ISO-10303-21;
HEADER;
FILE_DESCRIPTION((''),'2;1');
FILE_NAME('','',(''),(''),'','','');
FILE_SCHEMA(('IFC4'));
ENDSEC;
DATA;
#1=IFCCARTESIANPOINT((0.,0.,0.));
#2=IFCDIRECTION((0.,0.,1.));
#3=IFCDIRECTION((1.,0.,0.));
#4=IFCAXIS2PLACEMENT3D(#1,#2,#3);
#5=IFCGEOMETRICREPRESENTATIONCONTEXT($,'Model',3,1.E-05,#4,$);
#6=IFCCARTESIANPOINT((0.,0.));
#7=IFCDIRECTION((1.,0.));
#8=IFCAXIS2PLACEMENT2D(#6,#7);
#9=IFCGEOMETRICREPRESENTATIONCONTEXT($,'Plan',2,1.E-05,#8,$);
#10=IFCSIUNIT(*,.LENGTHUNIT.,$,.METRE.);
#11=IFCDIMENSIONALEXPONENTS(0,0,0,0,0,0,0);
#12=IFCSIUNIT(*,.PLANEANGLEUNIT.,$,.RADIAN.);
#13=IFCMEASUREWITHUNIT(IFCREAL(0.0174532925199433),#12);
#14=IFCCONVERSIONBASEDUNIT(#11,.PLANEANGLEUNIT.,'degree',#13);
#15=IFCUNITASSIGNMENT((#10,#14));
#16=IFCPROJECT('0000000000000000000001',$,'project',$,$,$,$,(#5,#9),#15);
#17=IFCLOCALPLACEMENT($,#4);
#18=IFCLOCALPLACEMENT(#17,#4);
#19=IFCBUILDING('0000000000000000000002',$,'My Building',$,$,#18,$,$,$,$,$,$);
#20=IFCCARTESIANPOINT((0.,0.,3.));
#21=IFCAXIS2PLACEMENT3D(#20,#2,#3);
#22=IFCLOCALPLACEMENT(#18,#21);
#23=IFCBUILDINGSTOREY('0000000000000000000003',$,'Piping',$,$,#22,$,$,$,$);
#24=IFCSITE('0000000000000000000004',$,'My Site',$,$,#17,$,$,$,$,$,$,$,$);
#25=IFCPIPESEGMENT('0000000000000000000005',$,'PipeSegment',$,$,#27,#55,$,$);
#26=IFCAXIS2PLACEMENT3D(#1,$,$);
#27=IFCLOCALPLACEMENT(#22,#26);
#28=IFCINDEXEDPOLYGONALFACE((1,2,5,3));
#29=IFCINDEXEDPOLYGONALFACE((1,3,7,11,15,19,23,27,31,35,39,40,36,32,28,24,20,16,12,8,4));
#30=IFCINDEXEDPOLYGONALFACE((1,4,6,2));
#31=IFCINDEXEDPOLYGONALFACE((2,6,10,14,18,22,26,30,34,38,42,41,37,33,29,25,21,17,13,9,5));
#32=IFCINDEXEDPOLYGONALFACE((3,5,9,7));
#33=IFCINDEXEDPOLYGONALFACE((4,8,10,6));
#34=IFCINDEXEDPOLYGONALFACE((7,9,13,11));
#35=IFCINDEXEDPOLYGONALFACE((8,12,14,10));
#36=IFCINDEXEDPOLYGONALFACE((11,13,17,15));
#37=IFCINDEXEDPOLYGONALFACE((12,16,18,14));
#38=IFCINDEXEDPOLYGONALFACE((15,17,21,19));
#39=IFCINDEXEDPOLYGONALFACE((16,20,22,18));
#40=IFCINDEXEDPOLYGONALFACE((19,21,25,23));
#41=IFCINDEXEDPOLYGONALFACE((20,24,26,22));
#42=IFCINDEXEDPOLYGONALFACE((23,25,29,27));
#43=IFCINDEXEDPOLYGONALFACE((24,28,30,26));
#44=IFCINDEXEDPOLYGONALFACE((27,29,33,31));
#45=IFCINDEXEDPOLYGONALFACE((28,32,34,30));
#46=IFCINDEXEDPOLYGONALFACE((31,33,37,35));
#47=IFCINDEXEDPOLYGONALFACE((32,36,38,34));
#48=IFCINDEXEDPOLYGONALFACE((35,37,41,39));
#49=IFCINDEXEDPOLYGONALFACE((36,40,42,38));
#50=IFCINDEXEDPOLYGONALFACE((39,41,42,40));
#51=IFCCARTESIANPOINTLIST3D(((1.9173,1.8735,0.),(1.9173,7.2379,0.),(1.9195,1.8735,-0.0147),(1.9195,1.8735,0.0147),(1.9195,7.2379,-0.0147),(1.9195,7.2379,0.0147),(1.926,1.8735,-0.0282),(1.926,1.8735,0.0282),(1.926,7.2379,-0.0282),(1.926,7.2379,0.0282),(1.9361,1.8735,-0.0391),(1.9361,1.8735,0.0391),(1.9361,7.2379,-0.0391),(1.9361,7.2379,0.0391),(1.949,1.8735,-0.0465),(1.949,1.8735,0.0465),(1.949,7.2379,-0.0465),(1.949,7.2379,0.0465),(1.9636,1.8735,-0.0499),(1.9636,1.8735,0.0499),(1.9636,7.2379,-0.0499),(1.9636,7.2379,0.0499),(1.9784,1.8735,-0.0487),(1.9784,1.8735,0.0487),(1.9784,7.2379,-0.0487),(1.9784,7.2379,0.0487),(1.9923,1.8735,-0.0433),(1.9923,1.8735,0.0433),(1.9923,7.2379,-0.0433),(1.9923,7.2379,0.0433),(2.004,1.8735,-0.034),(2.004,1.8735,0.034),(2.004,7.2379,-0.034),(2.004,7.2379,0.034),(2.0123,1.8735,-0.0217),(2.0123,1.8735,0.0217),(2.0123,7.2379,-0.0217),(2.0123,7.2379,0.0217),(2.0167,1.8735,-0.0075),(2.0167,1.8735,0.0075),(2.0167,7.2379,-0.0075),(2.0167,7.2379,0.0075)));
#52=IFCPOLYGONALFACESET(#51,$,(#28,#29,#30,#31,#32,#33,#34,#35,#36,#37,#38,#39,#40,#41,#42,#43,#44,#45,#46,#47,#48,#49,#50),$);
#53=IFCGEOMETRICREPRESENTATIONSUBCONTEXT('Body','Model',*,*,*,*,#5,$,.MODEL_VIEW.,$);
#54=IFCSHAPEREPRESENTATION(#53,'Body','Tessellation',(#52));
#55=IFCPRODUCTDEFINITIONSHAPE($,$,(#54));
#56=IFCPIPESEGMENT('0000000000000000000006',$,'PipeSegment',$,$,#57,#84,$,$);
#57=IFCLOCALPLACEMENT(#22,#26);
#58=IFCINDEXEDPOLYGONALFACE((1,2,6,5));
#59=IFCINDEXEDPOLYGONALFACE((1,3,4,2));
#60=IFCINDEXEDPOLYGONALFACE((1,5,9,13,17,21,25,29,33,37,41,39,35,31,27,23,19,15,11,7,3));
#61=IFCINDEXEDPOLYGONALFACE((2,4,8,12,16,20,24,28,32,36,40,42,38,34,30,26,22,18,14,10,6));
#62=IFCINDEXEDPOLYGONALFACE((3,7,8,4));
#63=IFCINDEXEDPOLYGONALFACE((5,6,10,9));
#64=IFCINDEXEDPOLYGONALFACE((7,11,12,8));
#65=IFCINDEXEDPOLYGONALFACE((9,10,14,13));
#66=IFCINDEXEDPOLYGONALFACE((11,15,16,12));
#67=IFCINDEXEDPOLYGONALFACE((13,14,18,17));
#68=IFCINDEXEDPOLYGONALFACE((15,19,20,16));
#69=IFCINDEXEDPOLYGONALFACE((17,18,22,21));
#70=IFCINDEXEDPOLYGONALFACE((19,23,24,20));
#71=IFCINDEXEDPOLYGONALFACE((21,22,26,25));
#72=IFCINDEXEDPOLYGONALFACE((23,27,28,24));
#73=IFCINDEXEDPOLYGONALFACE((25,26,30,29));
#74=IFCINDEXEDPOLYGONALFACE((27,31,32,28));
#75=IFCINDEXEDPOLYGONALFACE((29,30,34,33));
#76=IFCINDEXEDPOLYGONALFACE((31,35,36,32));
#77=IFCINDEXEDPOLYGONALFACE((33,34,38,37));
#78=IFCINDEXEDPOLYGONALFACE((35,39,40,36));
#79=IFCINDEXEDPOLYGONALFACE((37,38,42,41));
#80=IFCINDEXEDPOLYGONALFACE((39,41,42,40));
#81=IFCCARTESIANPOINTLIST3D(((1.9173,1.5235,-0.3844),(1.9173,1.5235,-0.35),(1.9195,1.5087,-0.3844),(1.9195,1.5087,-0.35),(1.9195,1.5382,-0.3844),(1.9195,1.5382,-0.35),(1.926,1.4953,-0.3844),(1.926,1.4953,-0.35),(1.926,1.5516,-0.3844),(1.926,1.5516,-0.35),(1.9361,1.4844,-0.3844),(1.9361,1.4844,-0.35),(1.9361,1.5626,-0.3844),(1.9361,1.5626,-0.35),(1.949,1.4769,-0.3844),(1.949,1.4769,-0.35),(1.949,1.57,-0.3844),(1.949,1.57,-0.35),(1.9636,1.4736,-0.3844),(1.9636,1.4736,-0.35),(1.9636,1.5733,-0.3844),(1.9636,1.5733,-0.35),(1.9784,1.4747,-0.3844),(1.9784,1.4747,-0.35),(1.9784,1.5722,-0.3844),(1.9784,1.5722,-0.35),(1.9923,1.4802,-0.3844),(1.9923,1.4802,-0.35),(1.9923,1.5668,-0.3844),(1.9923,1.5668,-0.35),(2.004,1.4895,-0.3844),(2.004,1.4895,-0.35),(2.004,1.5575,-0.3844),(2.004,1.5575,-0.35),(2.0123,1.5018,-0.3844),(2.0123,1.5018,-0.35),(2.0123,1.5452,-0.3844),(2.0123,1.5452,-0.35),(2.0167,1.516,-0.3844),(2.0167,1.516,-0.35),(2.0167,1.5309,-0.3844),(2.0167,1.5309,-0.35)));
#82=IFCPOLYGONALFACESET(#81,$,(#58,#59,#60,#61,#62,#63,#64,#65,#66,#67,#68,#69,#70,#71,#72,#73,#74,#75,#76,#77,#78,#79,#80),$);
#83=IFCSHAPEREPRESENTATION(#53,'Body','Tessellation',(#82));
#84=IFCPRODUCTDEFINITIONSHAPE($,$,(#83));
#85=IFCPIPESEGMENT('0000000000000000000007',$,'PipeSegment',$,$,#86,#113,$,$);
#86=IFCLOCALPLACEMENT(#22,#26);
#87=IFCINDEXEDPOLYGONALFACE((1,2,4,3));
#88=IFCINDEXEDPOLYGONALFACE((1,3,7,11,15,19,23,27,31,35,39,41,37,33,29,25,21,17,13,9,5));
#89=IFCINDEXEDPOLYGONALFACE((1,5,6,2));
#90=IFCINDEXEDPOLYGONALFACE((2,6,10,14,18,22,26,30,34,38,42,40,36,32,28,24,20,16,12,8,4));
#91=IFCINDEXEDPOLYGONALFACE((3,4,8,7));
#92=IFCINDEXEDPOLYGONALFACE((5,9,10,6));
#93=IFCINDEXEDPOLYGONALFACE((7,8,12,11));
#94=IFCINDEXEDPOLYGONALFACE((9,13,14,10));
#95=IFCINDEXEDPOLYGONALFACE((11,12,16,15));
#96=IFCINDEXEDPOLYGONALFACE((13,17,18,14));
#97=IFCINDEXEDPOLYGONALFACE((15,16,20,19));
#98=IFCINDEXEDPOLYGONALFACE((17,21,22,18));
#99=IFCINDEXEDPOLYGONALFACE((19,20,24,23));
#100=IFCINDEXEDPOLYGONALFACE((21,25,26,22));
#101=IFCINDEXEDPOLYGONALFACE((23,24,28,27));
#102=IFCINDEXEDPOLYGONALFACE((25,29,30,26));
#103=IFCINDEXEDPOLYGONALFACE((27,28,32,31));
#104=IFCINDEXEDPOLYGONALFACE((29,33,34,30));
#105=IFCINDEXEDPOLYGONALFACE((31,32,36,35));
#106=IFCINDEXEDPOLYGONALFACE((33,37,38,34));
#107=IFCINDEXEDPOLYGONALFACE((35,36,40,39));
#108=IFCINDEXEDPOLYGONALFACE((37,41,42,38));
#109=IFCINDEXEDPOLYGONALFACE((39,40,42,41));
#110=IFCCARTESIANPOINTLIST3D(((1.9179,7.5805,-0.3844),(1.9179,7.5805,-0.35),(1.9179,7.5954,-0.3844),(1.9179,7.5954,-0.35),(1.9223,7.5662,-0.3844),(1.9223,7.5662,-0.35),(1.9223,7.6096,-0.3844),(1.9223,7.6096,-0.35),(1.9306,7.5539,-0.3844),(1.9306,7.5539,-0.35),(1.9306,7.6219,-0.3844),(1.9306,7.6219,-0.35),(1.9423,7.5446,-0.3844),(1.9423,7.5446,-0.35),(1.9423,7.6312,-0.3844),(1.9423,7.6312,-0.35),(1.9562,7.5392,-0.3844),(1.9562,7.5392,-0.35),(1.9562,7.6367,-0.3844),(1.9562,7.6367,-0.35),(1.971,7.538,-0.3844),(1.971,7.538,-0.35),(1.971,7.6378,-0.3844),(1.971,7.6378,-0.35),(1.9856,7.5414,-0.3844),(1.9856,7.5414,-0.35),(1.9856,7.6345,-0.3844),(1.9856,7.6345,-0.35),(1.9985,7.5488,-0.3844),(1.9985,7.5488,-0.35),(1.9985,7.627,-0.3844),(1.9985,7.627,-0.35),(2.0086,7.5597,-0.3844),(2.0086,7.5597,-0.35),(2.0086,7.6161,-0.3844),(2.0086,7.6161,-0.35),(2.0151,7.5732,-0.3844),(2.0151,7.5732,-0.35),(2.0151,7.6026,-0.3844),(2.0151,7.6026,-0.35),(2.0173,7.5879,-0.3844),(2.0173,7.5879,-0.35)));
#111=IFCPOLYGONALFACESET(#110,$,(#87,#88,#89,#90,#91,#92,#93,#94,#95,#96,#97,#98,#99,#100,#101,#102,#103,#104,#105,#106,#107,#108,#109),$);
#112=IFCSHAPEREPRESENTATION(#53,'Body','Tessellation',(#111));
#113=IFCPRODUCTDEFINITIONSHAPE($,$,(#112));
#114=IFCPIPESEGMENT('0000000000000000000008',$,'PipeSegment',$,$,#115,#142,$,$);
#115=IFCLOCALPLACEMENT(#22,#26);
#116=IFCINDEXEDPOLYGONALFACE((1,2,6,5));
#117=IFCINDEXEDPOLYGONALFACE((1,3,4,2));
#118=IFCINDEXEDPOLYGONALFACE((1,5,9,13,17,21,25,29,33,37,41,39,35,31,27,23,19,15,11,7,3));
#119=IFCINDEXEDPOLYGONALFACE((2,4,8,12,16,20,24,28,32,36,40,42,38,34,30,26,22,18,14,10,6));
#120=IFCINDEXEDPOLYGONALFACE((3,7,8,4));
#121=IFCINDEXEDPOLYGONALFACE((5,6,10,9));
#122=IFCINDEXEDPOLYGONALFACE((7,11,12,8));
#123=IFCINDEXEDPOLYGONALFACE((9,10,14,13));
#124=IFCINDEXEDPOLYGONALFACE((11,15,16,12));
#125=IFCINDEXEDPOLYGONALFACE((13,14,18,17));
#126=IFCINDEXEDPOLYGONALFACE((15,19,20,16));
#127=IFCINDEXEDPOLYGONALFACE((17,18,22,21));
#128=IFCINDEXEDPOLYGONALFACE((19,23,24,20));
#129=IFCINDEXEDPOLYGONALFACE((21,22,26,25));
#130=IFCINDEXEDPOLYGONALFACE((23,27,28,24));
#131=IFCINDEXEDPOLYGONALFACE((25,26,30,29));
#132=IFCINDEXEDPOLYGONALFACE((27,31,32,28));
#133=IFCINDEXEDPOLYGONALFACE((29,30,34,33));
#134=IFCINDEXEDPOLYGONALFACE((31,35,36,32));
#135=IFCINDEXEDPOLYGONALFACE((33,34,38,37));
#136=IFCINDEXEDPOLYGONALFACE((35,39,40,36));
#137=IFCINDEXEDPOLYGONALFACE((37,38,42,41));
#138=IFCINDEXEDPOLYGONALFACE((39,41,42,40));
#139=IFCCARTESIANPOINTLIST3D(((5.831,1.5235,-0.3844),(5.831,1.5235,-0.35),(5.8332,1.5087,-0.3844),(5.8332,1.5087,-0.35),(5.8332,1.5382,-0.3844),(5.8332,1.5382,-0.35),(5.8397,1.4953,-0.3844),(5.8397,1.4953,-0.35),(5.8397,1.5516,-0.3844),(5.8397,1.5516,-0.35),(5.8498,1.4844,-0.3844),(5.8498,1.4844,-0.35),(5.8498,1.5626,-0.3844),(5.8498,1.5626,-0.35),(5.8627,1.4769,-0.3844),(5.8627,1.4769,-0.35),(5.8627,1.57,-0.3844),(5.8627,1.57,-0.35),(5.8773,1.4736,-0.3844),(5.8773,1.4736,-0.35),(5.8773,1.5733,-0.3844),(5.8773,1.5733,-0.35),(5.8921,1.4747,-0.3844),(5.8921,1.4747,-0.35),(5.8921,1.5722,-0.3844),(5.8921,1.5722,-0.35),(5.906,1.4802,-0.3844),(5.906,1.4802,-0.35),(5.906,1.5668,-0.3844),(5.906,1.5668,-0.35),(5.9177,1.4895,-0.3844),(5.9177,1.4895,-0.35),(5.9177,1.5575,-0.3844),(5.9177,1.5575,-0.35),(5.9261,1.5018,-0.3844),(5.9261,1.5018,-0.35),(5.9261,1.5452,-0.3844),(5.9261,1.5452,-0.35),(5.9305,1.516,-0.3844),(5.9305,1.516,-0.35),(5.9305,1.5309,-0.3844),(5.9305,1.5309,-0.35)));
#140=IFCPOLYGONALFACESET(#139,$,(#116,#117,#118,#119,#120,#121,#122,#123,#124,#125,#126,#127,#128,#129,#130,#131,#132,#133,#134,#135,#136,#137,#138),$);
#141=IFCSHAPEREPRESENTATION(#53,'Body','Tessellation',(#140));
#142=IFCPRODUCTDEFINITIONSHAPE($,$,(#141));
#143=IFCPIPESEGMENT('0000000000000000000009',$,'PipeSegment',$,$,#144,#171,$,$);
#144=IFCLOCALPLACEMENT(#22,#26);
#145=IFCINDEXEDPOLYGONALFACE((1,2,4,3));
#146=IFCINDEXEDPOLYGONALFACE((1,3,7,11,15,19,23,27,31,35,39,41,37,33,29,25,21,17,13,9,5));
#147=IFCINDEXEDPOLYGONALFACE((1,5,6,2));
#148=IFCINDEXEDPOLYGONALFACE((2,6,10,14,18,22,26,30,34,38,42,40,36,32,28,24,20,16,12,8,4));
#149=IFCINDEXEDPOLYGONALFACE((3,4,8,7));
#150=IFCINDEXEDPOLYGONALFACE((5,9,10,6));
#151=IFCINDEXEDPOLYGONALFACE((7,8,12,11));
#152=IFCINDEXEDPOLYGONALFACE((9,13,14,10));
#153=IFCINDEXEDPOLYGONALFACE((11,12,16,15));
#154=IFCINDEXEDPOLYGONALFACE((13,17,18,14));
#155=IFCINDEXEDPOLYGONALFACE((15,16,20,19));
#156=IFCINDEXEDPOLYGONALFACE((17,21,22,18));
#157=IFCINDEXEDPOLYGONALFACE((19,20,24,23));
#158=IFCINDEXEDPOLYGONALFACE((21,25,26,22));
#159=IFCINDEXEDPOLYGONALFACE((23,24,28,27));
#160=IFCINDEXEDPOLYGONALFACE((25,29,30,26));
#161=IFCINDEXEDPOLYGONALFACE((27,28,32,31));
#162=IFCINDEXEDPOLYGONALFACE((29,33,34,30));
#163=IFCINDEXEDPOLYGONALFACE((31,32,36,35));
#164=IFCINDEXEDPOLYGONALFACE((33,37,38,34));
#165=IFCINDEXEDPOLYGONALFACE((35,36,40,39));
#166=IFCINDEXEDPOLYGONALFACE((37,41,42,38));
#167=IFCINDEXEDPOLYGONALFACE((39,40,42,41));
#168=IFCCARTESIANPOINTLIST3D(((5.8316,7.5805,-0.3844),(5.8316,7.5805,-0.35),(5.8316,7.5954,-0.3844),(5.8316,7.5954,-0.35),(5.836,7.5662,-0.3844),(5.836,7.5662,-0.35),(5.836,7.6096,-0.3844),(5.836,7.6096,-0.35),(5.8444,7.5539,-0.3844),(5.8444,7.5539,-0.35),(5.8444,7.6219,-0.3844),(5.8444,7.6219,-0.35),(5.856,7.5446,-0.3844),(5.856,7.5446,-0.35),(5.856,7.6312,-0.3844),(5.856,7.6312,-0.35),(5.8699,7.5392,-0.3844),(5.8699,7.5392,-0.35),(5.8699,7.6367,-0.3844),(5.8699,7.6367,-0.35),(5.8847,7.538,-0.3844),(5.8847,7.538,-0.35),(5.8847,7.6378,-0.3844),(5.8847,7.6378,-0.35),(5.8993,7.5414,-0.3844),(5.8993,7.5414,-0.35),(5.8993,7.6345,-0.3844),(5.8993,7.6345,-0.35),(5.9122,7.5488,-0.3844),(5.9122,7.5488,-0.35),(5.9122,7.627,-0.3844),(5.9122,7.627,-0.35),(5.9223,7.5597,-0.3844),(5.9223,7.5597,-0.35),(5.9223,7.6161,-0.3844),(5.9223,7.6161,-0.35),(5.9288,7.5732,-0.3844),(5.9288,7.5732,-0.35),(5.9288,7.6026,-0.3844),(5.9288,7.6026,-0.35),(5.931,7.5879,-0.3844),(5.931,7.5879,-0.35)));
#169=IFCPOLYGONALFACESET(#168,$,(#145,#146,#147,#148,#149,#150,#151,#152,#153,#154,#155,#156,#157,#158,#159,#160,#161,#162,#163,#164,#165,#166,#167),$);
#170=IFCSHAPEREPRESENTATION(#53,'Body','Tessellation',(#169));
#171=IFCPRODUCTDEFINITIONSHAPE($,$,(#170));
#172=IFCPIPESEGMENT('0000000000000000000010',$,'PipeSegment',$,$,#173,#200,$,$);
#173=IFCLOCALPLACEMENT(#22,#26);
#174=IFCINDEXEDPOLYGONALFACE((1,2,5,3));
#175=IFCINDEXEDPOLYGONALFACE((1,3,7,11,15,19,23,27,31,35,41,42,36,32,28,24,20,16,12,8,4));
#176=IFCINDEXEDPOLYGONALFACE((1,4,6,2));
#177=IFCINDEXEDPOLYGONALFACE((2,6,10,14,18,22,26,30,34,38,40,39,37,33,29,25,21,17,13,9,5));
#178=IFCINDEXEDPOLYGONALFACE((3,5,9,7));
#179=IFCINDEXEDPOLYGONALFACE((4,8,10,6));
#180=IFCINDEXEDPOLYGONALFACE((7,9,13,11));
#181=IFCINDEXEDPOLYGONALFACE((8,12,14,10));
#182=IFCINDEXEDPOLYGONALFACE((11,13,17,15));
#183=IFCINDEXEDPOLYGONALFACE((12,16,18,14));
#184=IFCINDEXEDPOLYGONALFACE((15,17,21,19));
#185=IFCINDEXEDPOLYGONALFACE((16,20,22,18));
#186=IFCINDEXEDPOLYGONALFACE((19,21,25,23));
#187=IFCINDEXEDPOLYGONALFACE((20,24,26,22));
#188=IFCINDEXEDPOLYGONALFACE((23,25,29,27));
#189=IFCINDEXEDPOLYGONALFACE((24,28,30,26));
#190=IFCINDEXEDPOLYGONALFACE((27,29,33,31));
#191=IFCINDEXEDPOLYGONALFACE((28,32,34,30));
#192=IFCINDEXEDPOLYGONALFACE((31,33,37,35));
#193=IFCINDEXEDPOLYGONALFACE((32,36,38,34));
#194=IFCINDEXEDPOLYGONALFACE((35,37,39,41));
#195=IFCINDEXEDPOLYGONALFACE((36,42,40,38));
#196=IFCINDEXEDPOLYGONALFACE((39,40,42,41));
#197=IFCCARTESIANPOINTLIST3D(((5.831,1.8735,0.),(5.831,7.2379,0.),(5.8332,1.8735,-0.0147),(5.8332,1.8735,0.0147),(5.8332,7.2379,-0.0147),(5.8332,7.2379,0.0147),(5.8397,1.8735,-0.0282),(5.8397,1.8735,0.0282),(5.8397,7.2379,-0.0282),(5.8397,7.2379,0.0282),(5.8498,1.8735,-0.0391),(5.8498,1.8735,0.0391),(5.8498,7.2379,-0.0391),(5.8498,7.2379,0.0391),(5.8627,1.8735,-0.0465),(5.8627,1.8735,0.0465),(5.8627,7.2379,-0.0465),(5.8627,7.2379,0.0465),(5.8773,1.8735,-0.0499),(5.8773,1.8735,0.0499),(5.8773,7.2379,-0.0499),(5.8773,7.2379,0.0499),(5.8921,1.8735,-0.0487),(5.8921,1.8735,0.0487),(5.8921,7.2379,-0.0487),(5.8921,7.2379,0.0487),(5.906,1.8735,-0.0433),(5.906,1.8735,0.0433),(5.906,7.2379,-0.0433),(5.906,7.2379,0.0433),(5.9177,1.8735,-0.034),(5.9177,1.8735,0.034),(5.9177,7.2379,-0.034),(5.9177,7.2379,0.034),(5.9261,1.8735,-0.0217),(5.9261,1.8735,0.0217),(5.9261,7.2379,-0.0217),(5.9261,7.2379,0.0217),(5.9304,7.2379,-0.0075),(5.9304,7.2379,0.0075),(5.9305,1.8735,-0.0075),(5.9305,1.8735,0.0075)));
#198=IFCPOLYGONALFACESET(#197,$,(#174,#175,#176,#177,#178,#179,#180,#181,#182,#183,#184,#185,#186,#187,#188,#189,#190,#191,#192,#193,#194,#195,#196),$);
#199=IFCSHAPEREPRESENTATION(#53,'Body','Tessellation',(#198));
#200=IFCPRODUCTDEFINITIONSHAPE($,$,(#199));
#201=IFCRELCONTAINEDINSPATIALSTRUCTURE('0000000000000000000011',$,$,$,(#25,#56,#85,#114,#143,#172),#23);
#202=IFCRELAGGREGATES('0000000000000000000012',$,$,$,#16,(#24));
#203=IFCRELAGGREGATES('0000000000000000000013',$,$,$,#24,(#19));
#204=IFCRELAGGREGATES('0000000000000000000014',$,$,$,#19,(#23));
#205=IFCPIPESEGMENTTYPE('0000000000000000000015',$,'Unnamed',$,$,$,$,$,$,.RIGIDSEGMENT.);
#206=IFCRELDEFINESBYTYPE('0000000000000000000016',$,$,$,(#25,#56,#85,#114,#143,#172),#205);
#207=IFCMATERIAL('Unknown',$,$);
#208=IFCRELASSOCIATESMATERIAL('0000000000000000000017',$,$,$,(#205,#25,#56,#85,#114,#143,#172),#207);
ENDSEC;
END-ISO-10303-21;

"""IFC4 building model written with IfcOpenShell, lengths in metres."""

from ifc_helpers import new_model, entity, si_unit, converted_unit, frame, origin_with_axes, origin_2d_with_axis, place, context, subcontext, project, spatial, circle, extrude, material, material_profile, profile_set, profile_usage, type_object, element, save


model = new_model("IFC4")

# Units and contexts
model_context = context("Model", 3, precision=1e-05, world=origin_with_axes())
plan_context = context("Plan", 2, precision=1e-05, world=origin_2d_with_axis())
body_context = subcontext(model_context, "Body", "Model", "MODEL_VIEW")
ifc_project = project(units=[si_unit("LENGTHUNIT", "METRE"), converted_unit("PLANEANGLEUNIT", "degree", entity("IfcReal", 0.0174532925199433), si_unit("PLANEANGLEUNIT", "RADIAN"), dimensions=[0, 0, 0, 0, 0, 0, 0])], contexts=[model_context, plan_context])

# Site, building, storey
site_placement = place(None, origin_with_axes())
site = spatial("IfcSite", under=ifc_project, at=site_placement, Name="My Site")
building_placement = place(site_placement, origin_with_axes())
building = spatial("IfcBuilding", under=site, at=building_placement, Name="My Building")
storey_placement = place(building_placement, frame((0.0, 0.0, 3.0), z_axis=(0.0, 0.0, 1.0), x_axis=(1.0, 0.0, 0.0)))
storey = spatial("IfcBuildingStorey", under=building, at=storey_placement, Name="Piping")

# Pipe segments
ifc_material = material(Name="Unknown")
ifc_material_profile = material_profile(ifc_material, circle(Radius=0.05))
ifc_profile_set = profile_set([ifc_material_profile])
ifc_profile_usage_1 = profile_usage(ifc_profile_set, cardinal=5)
pipe_segment_type = type_object("IfcPipeSegmentType", Name="Unnamed", PredefinedType="RIGIDSEGMENT", material=ifc_profile_set)
pipe_segment_1_placement = place(storey_placement, frame((1.9673, 1.8735, 0.0), z_axis=(0.0, 1.0, 0.0), x_axis=(-1.0, 0.0, 0.0)))
element("IfcPipeSegment", 1, at=pipe_segment_1_placement, inside=storey, type_object=pipe_segment_type, material=ifc_profile_usage_1, Name="PipeSegment", context=body_context, shape_type="SweptSolid", body=[
    extrude(circle(Radius=0.05), origin_with_axes(), (0.0, 0.0, 1.0), 5.3645),
])
ifc_profile_usage_2 = profile_usage(ifc_profile_set, cardinal=5)
pipe_segment_2_placement = place(storey_placement, frame((1.9673, 1.5235, -0.35), z_axis=(0.0, 0.0, -1.0), x_axis=(-1.0, 0.0, 0.0)))
element("IfcPipeSegment", 2, at=pipe_segment_2_placement, inside=storey, type_object=pipe_segment_type, material=ifc_profile_usage_2, Name="PipeSegment", context=body_context, shape_type="SweptSolid", body=[
    extrude(circle(Radius=0.05), origin_with_axes(), (0.0, 0.0, 1.0), 0.0344),
])
ifc_profile_usage_3 = profile_usage(ifc_profile_set, cardinal=5)
pipe_segment_3_placement = place(storey_placement, frame((1.9673, 7.5879, -0.35), z_axis=(0.0, 0.0, -1.0), x_axis=(1.0, 0.0, 0.0)))
element("IfcPipeSegment", 3, at=pipe_segment_3_placement, inside=storey, type_object=pipe_segment_type, material=ifc_profile_usage_3, Name="PipeSegment", context=body_context, shape_type="SweptSolid", body=[
    extrude(circle(Radius=0.05), origin_with_axes(), (0.0, 0.0, 1.0), 0.0344),
])
ifc_profile_usage_4 = profile_usage(ifc_profile_set, cardinal=5)
pipe_segment_4_placement = place(storey_placement, frame((5.881, 1.5235, -0.35), z_axis=(0.0, 0.0, -1.0), x_axis=(-1.0, 0.0, 0.0)))
element("IfcPipeSegment", 4, at=pipe_segment_4_placement, inside=storey, type_object=pipe_segment_type, material=ifc_profile_usage_4, Name="PipeSegment", context=body_context, shape_type="SweptSolid", body=[
    extrude(circle(Radius=0.05), origin_with_axes(), (0.0, 0.0, 1.0), 0.0344),
])
ifc_profile_usage_5 = profile_usage(ifc_profile_set, cardinal=5)
pipe_segment_5_placement = place(storey_placement, frame((5.881, 7.5879, -0.35), z_axis=(0.0, 0.0, -1.0), x_axis=(1.0, 0.0, 0.0)))
element("IfcPipeSegment", 5, at=pipe_segment_5_placement, inside=storey, type_object=pipe_segment_type, material=ifc_profile_usage_5, Name="PipeSegment", context=body_context, shape_type="SweptSolid", body=[
    extrude(circle(Radius=0.05), origin_with_axes(), (0.0, 0.0, 1.0), 0.0344),
])
ifc_profile_usage_6 = profile_usage(ifc_profile_set, cardinal=5)
pipe_segment_6_placement = place(storey_placement, frame((5.881, 1.8735, 0.0), z_axis=(0.0, 1.0, 0.0), x_axis=(-1.0, 0.0, 0.0)))
element("IfcPipeSegment", 6, at=pipe_segment_6_placement, inside=storey, type_object=pipe_segment_type, material=ifc_profile_usage_6, Name="PipeSegment", context=body_context, shape_type="SweptSolid", body=[
    extrude(circle(Radius=0.05), origin_with_axes(), (0.0, 0.0, 1.0), 5.3645),
])

save(model, "model.ifc")
